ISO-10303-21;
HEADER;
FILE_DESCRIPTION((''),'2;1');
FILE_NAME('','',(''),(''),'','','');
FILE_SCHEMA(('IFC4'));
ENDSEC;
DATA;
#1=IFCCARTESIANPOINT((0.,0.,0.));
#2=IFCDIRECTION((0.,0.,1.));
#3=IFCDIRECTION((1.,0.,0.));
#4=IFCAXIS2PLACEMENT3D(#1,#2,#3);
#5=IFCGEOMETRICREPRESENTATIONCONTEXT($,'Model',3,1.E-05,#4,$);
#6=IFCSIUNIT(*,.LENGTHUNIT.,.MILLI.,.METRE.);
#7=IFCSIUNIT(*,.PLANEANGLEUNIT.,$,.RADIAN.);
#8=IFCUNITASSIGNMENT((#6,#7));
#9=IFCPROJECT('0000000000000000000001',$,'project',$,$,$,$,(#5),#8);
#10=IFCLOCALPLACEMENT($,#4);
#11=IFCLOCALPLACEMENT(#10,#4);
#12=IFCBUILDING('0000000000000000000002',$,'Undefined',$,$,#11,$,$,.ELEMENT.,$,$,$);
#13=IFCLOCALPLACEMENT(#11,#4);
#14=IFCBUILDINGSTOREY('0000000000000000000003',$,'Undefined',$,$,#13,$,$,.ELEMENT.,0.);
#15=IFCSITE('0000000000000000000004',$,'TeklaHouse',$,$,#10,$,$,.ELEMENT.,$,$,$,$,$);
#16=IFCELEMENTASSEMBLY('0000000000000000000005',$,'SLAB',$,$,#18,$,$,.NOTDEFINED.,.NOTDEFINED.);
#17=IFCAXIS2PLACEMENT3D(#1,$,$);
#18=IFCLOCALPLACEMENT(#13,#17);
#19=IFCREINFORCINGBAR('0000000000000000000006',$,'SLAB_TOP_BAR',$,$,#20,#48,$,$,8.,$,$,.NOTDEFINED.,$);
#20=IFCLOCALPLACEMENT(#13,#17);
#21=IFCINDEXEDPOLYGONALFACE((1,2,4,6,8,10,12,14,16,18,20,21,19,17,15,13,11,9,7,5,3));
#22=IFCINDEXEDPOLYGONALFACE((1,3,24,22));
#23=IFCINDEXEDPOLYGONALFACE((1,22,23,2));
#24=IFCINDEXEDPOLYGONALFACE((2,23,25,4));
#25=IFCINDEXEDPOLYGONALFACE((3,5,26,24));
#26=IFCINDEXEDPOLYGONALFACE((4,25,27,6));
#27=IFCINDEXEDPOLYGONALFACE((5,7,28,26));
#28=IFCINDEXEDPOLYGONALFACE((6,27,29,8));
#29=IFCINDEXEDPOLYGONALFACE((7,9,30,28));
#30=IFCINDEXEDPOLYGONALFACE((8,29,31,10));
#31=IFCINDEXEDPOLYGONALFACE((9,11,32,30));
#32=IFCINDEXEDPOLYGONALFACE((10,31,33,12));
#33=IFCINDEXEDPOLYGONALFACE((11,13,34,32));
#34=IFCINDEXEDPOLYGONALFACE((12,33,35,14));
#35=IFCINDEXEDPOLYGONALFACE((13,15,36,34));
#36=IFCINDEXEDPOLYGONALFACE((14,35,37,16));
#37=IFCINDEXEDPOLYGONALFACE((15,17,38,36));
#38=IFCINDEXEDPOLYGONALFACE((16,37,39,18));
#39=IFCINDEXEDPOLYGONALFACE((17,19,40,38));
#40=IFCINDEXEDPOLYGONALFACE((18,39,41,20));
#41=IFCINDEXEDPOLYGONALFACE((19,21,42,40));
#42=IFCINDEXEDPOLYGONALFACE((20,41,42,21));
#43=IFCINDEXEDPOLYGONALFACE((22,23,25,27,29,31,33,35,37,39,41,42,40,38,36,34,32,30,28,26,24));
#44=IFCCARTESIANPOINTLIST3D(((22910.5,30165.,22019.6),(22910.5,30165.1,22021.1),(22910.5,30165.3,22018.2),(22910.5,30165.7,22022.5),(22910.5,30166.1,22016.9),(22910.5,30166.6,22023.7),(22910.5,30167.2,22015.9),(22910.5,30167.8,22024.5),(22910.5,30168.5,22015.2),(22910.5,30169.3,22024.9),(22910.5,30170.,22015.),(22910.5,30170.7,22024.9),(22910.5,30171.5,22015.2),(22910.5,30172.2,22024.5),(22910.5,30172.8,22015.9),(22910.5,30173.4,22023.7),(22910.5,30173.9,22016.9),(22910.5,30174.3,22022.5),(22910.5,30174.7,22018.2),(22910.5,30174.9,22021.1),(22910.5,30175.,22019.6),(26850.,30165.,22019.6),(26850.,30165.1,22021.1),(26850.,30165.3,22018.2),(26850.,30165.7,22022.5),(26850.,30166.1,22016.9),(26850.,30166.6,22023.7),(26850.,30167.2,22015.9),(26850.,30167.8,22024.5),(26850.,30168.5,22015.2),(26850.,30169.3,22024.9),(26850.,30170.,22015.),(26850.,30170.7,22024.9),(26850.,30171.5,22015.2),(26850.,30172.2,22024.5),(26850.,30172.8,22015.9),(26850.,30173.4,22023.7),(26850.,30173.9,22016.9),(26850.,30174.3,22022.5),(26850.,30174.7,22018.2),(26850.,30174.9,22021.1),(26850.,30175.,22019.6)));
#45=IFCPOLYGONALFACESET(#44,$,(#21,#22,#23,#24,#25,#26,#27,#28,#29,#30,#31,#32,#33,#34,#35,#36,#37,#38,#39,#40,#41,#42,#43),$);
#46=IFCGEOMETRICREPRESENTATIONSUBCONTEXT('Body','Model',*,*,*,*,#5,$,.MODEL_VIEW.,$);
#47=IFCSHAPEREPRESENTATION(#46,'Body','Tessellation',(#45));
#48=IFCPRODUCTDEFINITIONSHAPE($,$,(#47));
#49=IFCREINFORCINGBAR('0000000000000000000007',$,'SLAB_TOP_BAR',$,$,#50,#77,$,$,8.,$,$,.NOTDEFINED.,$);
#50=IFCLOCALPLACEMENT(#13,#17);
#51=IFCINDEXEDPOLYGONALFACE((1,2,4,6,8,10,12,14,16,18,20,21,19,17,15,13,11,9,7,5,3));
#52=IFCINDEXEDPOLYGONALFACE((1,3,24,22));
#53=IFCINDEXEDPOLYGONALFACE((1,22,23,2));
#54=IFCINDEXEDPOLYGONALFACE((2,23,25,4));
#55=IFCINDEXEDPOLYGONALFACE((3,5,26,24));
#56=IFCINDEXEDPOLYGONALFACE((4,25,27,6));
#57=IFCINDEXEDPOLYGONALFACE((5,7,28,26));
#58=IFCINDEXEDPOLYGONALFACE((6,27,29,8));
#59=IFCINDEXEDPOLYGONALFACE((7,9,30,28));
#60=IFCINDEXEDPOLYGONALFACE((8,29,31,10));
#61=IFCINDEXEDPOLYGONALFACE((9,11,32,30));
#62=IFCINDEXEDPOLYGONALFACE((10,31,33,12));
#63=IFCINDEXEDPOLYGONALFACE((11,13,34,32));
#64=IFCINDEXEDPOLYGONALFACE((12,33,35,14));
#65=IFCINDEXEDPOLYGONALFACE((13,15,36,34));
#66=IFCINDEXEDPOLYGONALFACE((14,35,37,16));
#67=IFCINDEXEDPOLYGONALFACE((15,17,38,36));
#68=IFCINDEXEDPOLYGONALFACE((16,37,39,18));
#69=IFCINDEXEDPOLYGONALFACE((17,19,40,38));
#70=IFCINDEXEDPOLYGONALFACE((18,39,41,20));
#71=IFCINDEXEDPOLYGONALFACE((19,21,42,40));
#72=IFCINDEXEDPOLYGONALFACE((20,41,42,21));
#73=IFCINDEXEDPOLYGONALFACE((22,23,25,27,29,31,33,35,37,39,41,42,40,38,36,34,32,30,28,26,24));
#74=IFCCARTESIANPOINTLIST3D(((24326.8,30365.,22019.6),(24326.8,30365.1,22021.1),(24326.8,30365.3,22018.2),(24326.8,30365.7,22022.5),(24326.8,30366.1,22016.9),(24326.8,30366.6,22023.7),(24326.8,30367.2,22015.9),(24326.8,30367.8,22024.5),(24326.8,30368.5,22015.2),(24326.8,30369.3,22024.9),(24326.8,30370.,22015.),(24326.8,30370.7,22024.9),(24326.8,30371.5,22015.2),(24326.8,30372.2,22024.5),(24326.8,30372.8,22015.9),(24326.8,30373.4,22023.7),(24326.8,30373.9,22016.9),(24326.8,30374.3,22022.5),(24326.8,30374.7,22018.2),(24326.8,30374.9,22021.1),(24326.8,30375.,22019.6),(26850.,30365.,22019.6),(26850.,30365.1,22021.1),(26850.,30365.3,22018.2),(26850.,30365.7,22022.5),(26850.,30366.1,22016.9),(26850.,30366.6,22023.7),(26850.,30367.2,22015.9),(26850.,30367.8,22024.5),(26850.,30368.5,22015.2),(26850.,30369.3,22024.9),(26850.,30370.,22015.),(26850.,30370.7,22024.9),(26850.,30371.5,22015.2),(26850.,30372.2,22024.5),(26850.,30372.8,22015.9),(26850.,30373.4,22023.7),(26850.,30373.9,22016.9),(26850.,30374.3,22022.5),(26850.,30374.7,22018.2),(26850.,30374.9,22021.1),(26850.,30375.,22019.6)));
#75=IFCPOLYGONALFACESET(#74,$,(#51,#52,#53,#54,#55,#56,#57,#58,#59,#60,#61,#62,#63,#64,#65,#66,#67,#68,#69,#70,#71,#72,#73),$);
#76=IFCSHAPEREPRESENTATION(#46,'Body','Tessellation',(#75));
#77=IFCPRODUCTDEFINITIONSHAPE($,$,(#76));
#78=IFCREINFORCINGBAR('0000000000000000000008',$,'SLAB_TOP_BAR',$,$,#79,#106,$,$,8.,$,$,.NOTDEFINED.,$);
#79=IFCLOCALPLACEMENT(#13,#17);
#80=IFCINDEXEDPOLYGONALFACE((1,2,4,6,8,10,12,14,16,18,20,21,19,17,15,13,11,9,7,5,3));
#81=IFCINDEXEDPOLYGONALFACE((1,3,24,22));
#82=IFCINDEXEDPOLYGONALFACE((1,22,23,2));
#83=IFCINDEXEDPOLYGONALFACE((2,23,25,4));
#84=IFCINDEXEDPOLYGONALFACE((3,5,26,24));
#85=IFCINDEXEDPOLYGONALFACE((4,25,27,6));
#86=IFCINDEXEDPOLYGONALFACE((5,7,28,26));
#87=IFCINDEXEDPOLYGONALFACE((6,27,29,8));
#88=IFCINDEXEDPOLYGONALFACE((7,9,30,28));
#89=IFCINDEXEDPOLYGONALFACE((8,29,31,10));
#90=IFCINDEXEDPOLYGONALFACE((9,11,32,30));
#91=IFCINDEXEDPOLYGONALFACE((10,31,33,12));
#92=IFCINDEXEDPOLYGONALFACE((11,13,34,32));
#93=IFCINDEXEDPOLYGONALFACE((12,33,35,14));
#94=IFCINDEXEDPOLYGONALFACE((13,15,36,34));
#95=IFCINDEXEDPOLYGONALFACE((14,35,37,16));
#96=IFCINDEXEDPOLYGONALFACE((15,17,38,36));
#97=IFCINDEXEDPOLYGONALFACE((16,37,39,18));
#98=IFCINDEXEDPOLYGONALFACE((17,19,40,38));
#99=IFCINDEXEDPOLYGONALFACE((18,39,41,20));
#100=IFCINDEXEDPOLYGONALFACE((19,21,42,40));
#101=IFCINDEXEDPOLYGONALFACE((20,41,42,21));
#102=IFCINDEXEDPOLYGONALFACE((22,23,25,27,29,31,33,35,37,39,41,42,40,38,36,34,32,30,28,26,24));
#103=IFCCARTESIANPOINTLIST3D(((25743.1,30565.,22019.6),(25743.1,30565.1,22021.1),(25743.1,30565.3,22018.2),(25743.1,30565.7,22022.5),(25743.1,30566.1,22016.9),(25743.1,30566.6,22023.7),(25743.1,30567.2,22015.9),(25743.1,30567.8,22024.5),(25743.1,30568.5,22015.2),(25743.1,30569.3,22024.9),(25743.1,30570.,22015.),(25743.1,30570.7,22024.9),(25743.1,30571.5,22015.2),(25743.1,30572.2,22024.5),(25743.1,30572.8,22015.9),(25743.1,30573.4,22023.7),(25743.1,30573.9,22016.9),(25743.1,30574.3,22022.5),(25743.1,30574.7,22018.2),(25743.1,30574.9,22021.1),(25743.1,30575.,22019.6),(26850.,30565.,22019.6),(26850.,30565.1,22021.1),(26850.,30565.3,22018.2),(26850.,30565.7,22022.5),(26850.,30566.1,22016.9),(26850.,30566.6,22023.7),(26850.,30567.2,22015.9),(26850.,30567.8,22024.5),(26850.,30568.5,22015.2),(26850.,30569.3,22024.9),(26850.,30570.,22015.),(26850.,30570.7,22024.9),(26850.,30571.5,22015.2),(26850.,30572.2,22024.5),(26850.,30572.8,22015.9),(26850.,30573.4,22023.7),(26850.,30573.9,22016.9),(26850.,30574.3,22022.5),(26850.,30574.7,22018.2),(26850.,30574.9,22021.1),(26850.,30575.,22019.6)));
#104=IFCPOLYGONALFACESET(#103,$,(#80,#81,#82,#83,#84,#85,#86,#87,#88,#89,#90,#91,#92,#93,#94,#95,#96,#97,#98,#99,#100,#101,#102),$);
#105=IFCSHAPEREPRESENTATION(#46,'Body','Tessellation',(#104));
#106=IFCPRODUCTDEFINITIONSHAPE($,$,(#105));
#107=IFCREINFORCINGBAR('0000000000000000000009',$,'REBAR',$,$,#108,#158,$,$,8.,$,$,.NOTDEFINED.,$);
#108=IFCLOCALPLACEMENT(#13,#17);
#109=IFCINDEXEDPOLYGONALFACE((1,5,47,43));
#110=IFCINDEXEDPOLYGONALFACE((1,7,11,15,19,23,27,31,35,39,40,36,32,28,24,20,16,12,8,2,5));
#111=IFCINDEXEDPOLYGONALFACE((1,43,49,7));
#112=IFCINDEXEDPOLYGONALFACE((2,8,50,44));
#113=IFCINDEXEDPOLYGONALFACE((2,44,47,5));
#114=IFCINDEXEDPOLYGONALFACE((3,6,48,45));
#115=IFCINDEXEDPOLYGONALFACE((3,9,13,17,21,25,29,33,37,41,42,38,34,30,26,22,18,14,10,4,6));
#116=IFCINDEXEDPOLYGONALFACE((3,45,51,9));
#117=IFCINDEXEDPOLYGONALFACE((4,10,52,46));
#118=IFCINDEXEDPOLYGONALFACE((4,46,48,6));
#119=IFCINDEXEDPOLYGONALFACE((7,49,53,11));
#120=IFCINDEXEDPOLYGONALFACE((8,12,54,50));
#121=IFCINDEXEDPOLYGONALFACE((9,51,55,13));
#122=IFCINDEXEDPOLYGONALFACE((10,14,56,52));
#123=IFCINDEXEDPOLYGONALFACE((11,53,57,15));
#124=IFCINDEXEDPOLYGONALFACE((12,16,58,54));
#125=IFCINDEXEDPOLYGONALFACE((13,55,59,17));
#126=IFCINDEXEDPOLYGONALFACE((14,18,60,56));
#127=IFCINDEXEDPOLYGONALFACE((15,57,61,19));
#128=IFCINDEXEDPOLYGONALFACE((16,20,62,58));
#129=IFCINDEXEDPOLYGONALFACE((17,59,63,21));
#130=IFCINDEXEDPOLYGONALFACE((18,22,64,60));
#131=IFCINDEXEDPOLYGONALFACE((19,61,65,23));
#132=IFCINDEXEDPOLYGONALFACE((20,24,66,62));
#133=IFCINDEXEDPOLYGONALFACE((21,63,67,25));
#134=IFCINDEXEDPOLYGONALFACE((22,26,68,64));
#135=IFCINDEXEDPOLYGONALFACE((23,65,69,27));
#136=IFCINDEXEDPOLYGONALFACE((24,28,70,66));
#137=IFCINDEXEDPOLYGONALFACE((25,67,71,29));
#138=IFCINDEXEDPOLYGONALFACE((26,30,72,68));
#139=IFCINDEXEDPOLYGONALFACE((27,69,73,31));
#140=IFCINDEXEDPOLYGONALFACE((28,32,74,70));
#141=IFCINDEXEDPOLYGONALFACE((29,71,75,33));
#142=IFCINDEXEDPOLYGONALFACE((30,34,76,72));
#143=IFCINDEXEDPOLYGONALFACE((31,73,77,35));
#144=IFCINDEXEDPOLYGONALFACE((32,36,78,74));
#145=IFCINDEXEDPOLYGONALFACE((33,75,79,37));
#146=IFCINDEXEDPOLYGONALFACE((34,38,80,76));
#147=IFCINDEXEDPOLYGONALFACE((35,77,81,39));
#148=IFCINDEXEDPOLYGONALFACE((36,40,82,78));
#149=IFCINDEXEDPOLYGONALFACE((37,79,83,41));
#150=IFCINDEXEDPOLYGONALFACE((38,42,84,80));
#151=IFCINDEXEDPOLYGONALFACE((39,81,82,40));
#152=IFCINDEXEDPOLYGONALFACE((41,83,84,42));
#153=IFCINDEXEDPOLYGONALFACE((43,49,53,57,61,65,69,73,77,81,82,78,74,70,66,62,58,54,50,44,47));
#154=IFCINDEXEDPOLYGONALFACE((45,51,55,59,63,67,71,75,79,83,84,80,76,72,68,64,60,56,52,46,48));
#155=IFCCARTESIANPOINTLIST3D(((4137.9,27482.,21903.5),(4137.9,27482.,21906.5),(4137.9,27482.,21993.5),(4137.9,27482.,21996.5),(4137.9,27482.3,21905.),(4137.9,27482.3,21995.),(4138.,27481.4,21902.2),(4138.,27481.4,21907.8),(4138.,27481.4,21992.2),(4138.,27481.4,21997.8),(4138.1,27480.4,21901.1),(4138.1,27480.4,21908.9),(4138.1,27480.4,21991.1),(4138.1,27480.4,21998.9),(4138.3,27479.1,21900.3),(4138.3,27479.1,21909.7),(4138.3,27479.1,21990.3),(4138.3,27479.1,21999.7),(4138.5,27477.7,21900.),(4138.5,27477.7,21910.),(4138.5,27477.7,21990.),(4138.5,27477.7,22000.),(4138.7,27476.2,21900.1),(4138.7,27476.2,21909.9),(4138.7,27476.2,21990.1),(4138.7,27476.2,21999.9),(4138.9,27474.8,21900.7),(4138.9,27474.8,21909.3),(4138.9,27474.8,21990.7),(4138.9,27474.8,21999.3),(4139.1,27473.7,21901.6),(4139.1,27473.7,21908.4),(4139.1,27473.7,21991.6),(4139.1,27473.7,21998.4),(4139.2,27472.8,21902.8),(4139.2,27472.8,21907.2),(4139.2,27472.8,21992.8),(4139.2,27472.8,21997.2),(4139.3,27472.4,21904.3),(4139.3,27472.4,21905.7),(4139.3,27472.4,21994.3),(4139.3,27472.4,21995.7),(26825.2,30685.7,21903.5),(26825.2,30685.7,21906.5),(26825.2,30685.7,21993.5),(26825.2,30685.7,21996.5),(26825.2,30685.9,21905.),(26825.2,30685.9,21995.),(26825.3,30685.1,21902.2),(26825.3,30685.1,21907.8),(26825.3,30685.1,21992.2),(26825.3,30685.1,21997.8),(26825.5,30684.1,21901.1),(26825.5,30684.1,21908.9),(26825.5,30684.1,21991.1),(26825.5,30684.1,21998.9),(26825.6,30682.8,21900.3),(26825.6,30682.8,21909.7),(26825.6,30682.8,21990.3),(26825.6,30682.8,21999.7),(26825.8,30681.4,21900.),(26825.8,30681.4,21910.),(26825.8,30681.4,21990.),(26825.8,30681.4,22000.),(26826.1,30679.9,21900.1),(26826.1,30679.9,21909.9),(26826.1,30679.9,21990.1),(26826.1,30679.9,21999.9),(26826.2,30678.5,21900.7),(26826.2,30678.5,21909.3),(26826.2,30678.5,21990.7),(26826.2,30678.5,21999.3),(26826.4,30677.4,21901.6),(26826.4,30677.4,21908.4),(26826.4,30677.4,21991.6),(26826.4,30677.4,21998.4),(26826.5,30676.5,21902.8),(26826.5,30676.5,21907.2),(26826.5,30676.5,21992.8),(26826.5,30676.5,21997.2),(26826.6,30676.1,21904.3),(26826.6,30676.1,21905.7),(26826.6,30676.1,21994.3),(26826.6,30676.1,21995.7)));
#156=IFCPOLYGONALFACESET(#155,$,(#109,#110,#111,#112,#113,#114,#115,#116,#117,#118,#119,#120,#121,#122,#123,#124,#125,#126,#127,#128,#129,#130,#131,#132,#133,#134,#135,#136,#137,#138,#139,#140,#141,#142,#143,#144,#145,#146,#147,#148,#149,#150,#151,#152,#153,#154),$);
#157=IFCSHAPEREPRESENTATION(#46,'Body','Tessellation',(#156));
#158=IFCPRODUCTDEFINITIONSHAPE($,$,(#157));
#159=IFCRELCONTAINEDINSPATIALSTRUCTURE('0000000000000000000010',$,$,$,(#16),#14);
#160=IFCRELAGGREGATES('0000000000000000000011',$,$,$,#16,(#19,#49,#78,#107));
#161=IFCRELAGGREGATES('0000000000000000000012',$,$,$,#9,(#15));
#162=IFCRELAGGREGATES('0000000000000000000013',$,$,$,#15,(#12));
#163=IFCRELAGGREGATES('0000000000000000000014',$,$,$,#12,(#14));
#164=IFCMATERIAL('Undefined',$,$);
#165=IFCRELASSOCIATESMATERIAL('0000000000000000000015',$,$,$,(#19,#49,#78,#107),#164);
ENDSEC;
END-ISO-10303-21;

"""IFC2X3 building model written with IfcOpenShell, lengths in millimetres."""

from ifc_helpers import new_model, entity, si_unit, frame, origin_with_axes, place, context, subcontext, project, spatial, source, transform, mapped, material, element, aggregate, save


model = new_model("IFC2X3")

# Units and contexts
model_context = context("Model", 3, precision=1e-05, world=origin_with_axes())
body_context = subcontext(model_context, "Body", "Model", "MODEL_VIEW")
ifc_project = project(units=[si_unit("LENGTHUNIT", "METRE", prefix="MILLI"), si_unit("PLANEANGLEUNIT", "RADIAN")], contexts=[model_context])

# Site, building, storey
site_placement = place(None, origin_with_axes())
site = spatial("IfcSite", under=ifc_project, at=site_placement, Name="TeklaHouse", CompositionType="ELEMENT")
building_placement = place(site_placement, origin_with_axes())
building = spatial("IfcBuilding", under=site, at=building_placement, Name="Undefined", CompositionType="ELEMENT")
storey_placement = place(building_placement, origin_with_axes())
storey = spatial("IfcBuildingStorey", under=building, at=storey_placement, Name="Undefined", CompositionType="ELEMENT", Elevation=0.0)

# Element assembly, reinforcing bars
assembly_1_placement = place(storey_placement, origin_with_axes())
assembly_1 = element("IfcElementAssembly", 1, at=assembly_1_placement, inside=storey, Name="SLAB", AssemblyPlace="NOTDEFINED", PredefinedType="NOTDEFINED")
ifc_material_1 = material(Name="Undefined")
shared_shape_1 = source(origin_with_axes(), body_context, "Body", "AdvancedSweptSolid", [
    entity("IfcSweptDiskSolid", entity("IfcTrimmedCurve", entity("IfcLine", entity("IfcCartesianPoint", [0.0, 0.0, 0.0]), entity("IfcVector", entity("IfcDirection", [1.0, 0.0, 0.0]), 1.0)), [entity("IfcParameterValue", 0.0)], [entity("IfcParameterValue", 3939.51472)], True, "PARAMETER"), 5.0, None, 0.0, 3939.5),
])
reinforcing_bar_1_placement = place(assembly_1_placement, frame((26850.0, 30170.0, 22020.0), z_axis=(0.0, 0.0, -1.0), x_axis=(-1.0, 0.0, 0.0)))
reinforcing_bar_1 = element("IfcReinforcingBar", 2, at=reinforcing_bar_1_placement, material=ifc_material_1, Name="SLAB_TOP_BAR", BarRole="NOTDEFINED", NominalDiameter=8.0, context=body_context, shape_type="MappedRepresentation", body=[
    mapped(shared_shape_1, transform((0.0, 0.0, 0.0))),
])
shared_shape_2 = source(origin_with_axes(), body_context, "Body", "AdvancedSweptSolid", [
    entity("IfcSweptDiskSolid", entity("IfcTrimmedCurve", entity("IfcLine", entity("IfcCartesianPoint", [0.0, 0.0, 0.0]), entity("IfcVector", entity("IfcDirection", [1.0, 0.0, 0.0]), 1.0)), [entity("IfcParameterValue", 0.0)], [entity("IfcParameterValue", 2523.189984)], True, "PARAMETER"), 5.0, None, 0.0, 2523.2),
])
reinforcing_bar_2_placement = place(assembly_1_placement, frame((26850.0, 30370.0, 22020.0), z_axis=(0.0, 0.0, -1.0), x_axis=(-1.0, 0.0, 0.0)))
reinforcing_bar_2 = element("IfcReinforcingBar", 3, at=reinforcing_bar_2_placement, material=ifc_material_1, Name="SLAB_TOP_BAR", BarRole="NOTDEFINED", NominalDiameter=8.0, context=body_context, shape_type="MappedRepresentation", body=[
    mapped(shared_shape_2, transform((0.0, 0.0, 0.0))),
])
shared_shape_3 = source(origin_with_axes(), body_context, "Body", "AdvancedSweptSolid", [
    entity("IfcSweptDiskSolid", entity("IfcTrimmedCurve", entity("IfcLine", entity("IfcCartesianPoint", [0.0, 0.0, 0.0]), entity("IfcVector", entity("IfcDirection", [1.0, 0.0, 0.0]), 1.0)), [entity("IfcParameterValue", 0.0)], [entity("IfcParameterValue", 1106.865248)], True, "PARAMETER"), 5.0, None, 0.0, 1106.9),
])
reinforcing_bar_3_placement = place(assembly_1_placement, frame((26850.0, 30570.0, 22020.0), z_axis=(0.0, 0.0, -1.0), x_axis=(-1.0, 0.0, 0.0)))
reinforcing_bar_3 = element("IfcReinforcingBar", 4, at=reinforcing_bar_3_placement, material=ifc_material_1, Name="SLAB_TOP_BAR", BarRole="NOTDEFINED", NominalDiameter=8.0, context=body_context, shape_type="MappedRepresentation", body=[
    mapped(shared_shape_3, transform((0.0, 0.0, 0.0))),
])
shared_shape_4 = source(origin_with_axes(), body_context, "Body", "AdvancedSweptSolid", [
    entity("IfcSweptDiskSolid", entity("IfcTrimmedCurve", entity("IfcLine", entity("IfcCartesianPoint", [0.0, 0.0, 0.0]), entity("IfcVector", entity("IfcDirection", [1.0, 0.0, 0.0]), 1.0)), [entity("IfcParameterValue", 0.0)], [entity("IfcParameterValue", 22912.397366)], True, "PARAMETER"), 5.0, None, 0.0, 22912.4),
])
shared_shape_5 = source(origin_with_axes(), body_context, "Body", "AdvancedSweptSolid", [
    entity("IfcSweptDiskSolid", entity("IfcTrimmedCurve", entity("IfcLine", entity("IfcCartesianPoint", [0.0, 0.0, 0.0]), entity("IfcVector", entity("IfcDirection", [1.0, 0.0, 0.0]), 1.0)), [entity("IfcParameterValue", 0.0)], [entity("IfcParameterValue", 22912.397366)], True, "PARAMETER"), 5.0, None, 0.0, 22912.4),
])
reinforcing_bar_4_placement = place(assembly_1_placement, frame((26825.9, 30681.0, 21905.0), z_axis=(-0.139823, 0.990176, 0.0), x_axis=(-0.990176, -0.139823, 0.0)))
reinforcing_bar_4 = element("IfcReinforcingBar", 5, at=reinforcing_bar_4_placement, material=ifc_material_1, Name="REBAR", BarRole="NOTDEFINED", NominalDiameter=8.0, context=body_context, shape_type="MappedRepresentation", body=[
    mapped(shared_shape_4, transform((0.0, 0.0, 0.0))),
    mapped(shared_shape_5, transform((0.0, 90.0, 0.0))),
])
aggregate(assembly_1, [reinforcing_bar_1, reinforcing_bar_2, reinforcing_bar_3, reinforcing_bar_4])

save(model, "model.ifc")
